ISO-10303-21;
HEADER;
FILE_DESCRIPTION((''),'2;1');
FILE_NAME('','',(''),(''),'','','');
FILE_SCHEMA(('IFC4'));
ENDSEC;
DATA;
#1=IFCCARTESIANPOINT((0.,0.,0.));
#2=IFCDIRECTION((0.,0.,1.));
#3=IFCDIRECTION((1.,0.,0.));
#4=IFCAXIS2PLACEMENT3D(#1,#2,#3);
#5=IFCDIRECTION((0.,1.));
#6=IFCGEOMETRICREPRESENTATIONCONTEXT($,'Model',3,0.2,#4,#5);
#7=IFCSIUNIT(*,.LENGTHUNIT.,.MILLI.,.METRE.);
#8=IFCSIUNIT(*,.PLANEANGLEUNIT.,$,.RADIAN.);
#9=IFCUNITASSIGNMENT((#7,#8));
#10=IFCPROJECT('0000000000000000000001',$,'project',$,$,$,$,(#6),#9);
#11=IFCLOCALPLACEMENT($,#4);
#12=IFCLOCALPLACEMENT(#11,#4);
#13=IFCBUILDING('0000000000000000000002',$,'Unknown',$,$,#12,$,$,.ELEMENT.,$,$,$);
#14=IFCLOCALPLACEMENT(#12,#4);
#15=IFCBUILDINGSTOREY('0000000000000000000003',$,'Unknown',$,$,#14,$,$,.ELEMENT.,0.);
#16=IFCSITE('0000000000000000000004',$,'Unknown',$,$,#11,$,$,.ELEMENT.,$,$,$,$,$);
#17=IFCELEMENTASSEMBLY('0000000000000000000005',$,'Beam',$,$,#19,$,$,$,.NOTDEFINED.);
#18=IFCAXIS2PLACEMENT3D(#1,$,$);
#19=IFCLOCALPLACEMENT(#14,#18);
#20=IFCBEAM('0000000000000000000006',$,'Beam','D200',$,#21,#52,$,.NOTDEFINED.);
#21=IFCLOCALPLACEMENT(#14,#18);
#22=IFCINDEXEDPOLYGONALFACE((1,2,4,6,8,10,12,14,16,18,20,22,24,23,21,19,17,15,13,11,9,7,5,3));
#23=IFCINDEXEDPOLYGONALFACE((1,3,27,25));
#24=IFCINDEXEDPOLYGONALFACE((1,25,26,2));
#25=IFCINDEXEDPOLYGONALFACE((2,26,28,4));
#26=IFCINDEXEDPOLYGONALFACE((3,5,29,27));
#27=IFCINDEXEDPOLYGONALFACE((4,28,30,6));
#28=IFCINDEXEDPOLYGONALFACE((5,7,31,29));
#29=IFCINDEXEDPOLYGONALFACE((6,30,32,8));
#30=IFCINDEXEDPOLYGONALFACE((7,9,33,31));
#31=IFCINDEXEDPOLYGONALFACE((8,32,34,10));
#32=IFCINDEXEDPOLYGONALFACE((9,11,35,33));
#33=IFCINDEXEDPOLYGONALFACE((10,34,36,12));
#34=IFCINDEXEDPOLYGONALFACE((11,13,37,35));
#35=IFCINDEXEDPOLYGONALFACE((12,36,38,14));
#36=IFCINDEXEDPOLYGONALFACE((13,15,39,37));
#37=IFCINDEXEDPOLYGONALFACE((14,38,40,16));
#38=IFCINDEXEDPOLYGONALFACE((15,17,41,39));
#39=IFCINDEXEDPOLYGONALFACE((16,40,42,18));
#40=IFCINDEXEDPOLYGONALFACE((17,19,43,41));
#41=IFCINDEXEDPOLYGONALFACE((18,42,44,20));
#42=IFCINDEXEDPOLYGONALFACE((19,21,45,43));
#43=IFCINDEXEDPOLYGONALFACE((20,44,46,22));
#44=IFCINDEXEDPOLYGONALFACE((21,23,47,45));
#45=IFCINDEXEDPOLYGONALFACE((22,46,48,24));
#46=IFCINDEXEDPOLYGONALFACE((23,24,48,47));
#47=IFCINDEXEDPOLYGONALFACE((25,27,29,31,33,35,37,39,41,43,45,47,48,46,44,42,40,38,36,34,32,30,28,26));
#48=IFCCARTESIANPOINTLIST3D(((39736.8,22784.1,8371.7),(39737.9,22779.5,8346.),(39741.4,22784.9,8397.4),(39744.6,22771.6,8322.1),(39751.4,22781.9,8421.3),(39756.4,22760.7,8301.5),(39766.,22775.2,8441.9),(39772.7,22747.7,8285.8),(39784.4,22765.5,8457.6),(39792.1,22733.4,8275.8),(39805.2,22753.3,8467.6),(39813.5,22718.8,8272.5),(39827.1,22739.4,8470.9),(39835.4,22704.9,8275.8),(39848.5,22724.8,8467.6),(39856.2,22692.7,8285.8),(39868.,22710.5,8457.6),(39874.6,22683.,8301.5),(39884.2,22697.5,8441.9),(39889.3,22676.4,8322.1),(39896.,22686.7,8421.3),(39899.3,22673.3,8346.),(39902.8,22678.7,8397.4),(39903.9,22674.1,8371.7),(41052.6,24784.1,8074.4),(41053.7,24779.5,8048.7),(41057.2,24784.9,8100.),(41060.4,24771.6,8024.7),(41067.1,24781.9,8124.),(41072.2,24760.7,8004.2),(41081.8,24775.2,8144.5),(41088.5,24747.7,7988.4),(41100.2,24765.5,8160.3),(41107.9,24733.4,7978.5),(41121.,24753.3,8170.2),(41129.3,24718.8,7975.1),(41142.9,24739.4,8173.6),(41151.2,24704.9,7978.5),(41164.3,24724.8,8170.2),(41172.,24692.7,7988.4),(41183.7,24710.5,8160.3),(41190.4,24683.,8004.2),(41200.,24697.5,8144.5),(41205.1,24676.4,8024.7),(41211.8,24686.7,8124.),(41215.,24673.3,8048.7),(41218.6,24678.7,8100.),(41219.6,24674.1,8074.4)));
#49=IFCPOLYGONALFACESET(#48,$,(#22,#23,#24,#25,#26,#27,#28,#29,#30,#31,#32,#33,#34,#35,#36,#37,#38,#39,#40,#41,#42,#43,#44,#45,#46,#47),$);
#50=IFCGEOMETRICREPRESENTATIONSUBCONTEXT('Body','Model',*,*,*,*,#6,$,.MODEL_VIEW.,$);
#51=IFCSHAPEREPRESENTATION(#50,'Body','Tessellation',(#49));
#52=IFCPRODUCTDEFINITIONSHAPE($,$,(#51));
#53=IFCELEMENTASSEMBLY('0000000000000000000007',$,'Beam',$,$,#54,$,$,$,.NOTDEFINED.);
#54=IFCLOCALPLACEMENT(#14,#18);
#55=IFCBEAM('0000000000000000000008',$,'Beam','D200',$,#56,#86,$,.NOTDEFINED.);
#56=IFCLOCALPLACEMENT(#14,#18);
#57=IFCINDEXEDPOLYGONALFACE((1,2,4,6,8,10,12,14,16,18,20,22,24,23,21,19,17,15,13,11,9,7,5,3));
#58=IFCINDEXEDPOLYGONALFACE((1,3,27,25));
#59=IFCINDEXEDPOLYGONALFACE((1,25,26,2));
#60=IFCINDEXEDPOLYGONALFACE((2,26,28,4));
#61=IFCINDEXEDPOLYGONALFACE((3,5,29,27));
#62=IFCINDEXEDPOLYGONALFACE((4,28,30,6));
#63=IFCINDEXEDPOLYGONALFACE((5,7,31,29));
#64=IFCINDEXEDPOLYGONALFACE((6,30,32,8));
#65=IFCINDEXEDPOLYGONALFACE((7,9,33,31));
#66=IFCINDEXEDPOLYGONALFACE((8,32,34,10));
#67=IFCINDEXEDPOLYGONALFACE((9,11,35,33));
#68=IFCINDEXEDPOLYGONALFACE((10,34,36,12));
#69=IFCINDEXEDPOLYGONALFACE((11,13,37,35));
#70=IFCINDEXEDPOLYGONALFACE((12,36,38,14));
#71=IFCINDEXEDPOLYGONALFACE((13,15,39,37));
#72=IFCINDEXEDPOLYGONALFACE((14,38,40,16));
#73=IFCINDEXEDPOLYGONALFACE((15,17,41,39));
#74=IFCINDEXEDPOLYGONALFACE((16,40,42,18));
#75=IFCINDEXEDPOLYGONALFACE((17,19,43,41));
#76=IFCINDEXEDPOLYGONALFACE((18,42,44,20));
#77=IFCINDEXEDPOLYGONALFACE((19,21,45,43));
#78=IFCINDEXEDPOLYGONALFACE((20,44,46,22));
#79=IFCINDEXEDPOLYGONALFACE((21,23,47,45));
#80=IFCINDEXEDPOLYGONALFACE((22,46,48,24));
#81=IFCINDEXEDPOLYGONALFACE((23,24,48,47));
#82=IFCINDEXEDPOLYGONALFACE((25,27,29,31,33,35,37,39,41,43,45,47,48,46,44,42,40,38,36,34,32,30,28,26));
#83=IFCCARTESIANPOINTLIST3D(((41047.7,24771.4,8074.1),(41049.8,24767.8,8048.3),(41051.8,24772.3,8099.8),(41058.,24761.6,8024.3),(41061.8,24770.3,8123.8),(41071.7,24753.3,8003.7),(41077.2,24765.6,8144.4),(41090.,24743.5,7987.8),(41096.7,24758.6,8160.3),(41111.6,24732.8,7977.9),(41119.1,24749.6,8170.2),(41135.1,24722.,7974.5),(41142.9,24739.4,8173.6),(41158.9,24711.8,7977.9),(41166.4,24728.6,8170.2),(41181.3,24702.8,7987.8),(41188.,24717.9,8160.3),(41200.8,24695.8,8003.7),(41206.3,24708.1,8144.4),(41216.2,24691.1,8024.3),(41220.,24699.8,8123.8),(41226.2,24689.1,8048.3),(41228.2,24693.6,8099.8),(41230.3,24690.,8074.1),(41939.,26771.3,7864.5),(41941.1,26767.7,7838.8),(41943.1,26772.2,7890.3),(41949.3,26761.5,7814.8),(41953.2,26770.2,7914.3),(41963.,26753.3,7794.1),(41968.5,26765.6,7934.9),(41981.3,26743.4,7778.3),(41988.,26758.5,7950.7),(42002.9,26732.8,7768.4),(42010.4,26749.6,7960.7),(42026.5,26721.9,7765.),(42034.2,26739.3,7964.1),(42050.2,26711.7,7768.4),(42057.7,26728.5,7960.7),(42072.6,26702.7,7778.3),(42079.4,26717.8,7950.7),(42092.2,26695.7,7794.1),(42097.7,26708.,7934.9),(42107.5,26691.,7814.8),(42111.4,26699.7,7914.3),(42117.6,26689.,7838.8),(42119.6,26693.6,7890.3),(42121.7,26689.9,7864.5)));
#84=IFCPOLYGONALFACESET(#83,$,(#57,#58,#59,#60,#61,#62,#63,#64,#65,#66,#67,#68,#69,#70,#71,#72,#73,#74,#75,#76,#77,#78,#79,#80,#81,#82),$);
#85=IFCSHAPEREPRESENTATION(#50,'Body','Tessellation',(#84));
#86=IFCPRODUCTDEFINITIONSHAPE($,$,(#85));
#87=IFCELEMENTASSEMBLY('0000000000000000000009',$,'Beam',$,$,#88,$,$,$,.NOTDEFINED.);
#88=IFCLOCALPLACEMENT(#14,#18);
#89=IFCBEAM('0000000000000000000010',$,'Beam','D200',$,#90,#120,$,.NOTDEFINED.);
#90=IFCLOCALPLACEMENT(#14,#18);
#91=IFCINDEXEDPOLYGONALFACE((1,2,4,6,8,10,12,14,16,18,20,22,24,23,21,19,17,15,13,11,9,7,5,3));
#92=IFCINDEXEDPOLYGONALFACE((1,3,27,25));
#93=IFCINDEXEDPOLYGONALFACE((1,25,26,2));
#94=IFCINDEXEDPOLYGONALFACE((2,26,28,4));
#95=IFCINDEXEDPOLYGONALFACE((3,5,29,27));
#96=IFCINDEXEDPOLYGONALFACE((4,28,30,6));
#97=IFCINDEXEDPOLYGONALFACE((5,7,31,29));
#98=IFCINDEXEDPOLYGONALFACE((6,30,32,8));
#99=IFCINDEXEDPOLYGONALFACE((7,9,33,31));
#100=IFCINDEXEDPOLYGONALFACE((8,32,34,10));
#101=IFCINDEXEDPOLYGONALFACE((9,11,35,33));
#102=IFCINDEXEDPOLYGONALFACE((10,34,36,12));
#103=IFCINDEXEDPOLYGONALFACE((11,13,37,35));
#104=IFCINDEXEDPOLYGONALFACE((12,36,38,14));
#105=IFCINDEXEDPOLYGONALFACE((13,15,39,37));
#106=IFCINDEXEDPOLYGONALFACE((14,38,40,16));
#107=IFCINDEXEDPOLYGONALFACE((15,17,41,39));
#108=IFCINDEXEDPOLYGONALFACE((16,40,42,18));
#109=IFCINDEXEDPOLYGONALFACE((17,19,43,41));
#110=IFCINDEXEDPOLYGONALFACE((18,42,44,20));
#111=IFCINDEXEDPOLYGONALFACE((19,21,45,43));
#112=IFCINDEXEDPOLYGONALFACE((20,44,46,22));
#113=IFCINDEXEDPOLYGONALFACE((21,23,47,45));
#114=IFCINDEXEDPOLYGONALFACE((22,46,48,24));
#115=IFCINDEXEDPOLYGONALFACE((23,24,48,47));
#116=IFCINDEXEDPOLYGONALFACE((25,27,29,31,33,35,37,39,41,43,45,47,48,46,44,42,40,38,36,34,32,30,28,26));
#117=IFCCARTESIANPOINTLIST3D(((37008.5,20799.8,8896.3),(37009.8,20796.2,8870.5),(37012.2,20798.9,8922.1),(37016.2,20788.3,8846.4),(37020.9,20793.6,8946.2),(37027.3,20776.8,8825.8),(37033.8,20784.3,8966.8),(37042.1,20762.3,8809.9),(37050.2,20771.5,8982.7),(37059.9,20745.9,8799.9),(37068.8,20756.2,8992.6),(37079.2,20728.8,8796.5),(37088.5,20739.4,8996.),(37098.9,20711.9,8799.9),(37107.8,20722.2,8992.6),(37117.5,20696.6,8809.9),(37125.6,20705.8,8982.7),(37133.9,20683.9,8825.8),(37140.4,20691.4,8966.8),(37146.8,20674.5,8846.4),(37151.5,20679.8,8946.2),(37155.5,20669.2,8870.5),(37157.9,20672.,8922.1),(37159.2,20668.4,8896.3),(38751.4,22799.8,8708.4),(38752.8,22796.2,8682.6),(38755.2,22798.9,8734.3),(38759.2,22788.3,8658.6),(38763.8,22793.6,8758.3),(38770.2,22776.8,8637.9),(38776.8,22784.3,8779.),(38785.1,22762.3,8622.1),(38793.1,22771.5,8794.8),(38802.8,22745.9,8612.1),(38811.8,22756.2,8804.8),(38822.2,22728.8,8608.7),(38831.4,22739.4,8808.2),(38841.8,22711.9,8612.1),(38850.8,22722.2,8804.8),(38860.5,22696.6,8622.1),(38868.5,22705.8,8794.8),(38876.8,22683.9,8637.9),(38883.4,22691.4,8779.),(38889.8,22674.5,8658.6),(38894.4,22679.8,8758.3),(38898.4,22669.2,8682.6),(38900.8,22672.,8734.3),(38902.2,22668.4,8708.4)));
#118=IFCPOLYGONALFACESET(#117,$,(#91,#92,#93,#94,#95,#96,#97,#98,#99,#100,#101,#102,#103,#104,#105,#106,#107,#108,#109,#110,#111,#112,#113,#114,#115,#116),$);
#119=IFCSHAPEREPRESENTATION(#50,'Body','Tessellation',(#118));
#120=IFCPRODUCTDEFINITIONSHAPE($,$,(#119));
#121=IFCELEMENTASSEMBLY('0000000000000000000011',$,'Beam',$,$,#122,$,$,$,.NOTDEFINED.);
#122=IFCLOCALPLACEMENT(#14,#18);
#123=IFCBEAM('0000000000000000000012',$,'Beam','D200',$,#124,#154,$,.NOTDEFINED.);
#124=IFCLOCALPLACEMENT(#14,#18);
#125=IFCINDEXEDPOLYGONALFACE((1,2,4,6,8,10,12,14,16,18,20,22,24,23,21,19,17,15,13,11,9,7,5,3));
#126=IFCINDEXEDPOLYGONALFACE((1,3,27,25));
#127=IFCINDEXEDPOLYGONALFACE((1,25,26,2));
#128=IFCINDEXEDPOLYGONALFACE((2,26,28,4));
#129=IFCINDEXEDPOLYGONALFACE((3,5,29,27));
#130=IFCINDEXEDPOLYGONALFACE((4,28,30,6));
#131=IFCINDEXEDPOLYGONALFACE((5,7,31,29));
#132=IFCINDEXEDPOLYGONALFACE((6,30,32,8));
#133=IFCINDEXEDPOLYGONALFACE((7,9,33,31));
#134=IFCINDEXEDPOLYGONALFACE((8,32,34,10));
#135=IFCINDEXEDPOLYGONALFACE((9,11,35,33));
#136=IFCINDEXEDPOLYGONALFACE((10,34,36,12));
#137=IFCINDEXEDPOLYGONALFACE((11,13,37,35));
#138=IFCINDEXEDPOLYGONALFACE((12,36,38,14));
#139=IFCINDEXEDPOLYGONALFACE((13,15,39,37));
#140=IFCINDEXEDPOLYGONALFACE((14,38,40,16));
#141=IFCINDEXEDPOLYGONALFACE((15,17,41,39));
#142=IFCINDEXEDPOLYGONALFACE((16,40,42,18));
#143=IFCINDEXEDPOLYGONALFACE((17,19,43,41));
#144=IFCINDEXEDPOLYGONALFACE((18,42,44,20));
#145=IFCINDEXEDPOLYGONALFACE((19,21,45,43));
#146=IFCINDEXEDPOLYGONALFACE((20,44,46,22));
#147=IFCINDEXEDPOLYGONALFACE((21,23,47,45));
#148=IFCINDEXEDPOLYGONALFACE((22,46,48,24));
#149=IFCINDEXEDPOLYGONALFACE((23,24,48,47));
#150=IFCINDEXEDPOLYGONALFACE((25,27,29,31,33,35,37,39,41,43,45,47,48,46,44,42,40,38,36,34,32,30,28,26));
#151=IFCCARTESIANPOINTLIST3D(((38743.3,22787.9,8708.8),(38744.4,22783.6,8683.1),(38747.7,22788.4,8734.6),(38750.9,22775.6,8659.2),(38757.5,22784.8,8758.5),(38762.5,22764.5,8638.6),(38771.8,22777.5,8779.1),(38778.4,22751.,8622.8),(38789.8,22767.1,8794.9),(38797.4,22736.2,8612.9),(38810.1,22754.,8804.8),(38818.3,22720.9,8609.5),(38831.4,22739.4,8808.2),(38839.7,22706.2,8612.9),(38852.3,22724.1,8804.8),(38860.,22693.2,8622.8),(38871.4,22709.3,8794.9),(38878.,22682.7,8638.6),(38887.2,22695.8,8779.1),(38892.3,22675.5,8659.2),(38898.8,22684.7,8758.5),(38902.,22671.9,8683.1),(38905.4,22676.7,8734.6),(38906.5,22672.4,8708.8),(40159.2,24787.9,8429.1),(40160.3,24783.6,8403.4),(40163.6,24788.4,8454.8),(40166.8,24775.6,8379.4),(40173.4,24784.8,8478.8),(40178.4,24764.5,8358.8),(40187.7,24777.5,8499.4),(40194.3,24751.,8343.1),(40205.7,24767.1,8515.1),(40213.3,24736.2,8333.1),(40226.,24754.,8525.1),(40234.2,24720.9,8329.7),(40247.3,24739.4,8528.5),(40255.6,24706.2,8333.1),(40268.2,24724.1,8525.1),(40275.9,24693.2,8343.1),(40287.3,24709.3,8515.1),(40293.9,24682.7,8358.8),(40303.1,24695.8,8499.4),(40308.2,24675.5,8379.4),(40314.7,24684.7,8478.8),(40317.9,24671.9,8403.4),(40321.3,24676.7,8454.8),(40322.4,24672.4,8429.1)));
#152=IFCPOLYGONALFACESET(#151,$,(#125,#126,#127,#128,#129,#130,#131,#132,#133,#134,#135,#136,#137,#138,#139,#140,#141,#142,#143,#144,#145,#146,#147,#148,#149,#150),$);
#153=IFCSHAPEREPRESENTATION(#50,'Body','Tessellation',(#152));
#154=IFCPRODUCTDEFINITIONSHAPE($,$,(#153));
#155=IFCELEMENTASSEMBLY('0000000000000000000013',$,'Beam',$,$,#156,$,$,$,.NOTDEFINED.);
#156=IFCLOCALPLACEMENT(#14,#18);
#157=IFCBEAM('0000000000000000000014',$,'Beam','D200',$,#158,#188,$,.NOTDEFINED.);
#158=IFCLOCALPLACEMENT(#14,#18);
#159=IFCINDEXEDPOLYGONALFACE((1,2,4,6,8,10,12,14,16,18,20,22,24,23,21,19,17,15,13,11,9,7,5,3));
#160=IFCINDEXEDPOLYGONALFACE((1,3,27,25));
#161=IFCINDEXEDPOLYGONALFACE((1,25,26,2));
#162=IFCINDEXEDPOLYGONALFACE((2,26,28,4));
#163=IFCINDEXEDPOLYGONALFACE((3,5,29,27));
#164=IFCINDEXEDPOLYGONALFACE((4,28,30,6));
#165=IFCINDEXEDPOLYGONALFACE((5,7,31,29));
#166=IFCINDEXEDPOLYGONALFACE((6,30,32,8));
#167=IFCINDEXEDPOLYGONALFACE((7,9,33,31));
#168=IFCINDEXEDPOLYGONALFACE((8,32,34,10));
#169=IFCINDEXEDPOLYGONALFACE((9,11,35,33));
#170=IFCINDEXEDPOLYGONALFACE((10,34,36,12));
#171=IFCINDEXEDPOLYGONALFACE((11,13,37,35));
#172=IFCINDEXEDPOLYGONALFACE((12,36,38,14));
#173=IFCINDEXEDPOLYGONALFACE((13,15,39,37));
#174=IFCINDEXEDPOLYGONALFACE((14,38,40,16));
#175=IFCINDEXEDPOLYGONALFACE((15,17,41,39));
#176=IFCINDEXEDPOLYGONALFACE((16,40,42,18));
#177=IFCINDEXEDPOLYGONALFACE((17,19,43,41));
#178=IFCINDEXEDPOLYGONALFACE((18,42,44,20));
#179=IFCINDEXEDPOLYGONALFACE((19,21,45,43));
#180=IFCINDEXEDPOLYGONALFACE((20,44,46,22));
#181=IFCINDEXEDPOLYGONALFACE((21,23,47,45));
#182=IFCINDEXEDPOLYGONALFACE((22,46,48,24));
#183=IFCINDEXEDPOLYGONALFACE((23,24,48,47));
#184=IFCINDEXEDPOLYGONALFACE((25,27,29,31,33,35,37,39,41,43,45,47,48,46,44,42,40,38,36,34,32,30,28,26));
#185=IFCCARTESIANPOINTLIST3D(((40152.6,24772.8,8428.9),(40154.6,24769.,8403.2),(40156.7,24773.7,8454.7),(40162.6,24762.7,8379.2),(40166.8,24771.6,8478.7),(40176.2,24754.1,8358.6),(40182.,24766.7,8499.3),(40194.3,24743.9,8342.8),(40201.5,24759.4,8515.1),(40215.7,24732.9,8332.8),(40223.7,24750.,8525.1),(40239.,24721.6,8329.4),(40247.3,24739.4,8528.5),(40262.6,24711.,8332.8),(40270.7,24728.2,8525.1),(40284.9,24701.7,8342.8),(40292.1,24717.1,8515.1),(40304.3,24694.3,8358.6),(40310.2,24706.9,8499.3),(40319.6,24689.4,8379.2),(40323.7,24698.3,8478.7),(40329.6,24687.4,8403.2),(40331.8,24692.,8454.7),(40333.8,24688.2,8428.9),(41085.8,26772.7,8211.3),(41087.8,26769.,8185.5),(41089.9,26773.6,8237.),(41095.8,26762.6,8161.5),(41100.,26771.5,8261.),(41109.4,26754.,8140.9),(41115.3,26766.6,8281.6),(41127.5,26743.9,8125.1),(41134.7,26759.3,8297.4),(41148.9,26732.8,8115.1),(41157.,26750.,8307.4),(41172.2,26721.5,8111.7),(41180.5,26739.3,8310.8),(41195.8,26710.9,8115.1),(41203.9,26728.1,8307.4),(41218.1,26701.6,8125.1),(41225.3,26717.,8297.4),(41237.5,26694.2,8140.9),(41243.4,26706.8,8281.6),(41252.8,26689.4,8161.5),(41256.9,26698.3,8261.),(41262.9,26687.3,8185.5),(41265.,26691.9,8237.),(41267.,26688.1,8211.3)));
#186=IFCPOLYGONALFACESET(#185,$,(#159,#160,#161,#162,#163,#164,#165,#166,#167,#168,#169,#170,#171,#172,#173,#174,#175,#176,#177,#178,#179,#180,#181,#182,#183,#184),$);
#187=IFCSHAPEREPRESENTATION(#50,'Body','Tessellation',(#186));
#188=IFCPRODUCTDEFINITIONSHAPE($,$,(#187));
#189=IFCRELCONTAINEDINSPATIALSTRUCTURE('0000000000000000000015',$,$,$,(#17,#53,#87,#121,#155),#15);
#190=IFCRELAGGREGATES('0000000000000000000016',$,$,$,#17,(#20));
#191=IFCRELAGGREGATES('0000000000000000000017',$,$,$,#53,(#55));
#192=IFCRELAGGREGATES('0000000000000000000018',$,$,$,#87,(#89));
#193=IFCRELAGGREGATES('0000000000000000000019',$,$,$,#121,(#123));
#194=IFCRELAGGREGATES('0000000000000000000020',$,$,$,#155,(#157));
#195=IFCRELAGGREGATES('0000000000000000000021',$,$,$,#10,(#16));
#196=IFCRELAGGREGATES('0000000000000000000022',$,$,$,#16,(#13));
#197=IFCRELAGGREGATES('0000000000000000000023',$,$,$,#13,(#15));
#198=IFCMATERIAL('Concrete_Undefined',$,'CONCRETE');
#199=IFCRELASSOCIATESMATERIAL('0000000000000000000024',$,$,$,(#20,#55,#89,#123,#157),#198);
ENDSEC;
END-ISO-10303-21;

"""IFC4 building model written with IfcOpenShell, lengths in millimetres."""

from ifc_helpers import new_model, si_unit, direction, frame, origin_with_axes, place, context, subcontext, project, spatial, line, indexed_curve, outline, extrude, material, element, aggregate, save


model = new_model("IFC4")

# Units and contexts
model_context = context("Model", 3, precision=0.2, world=origin_with_axes(), true_north=direction((0.0, 1.0)))
body_context = subcontext(model_context, "Body", "Model", "MODEL_VIEW")
ifc_project = project(units=[si_unit("LENGTHUNIT", "METRE", prefix="MILLI"), si_unit("PLANEANGLEUNIT", "RADIAN")], contexts=[model_context])

# Site, building, storey
site_placement = place(None, origin_with_axes())
site = spatial("IfcSite", under=ifc_project, at=site_placement, Name="Unknown", CompositionType="ELEMENT")
building_placement = place(site_placement, origin_with_axes())
building = spatial("IfcBuilding", under=site, at=building_placement, Name="Unknown", CompositionType="ELEMENT")
storey_placement = place(building_placement, origin_with_axes())
storey = spatial("IfcBuildingStorey", under=building, at=storey_placement, Name="Unknown", CompositionType="ELEMENT", Elevation=0.0)

# Element assemblies, beams
ifc_material = material(Name="Concrete_Undefined", Category="CONCRETE")
assembly_1_placement = place(storey_placement, frame((41136.1, 24729.1, 8074.4), z_axis=(-0.835416, 0.549618, 0.0), x_axis=(-0.545427, -0.829046, 0.123255)))
assembly_1 = element("IfcElementAssembly", 1, at=assembly_1_placement, inside=storey, Name="Beam", PredefinedType="NOTDEFINED")
beam_1_placement = place(assembly_1_placement, origin_with_axes())
beam_1 = element("IfcBeam", 2, at=beam_1_placement, material=ifc_material, Name="Beam", Description="D200", PredefinedType="NOTDEFINED", context=body_context, shape_type="SolidModel", body=[
    extrude(outline(indexed_curve([(100.0, 0.0), (96.6, 25.9), (86.6, 50.0), (70.7, 70.7), (50.0, 86.6), (25.9, 96.6), (0.0, 100.0), (-25.9, 96.6), (-50.0, 86.6), (-70.7, 70.7), (-86.6, 50.0), (-96.6, 25.9), (-100.0, 0.0), (-96.6, -25.9), (-86.6, -50.0), (-70.7, -70.7), (-50.0, -86.6), (-25.9, -96.6), (0.0, -100.0), (25.9, -96.6), (50.0, -86.6), (70.7, -70.7), (86.6, -50.0), (96.6, -25.9)], segments=[line(1, 2, 3, 4, 5, 6, 7, 8, 9, 10, 11, 12, 13, 14, 15, 16, 17, 18, 19, 20, 21, 22, 23, 24, 1)])), frame((0.0, 0.0, 0.0), z_axis=(-1.0, 0.0, 0.0), x_axis=(0.0, 0.0, 1.0)), (0.0, 0.0, -1.0), 2412.4),
])
aggregate(assembly_1, [beam_1])
assembly_2_placement = place(storey_placement, frame((42030.3, 26730.6, 7864.5), z_axis=(-0.913392, 0.407082, 0.0), x_axis=(-0.405231, -0.909239, 0.095254)))
assembly_2 = element("IfcElementAssembly", 3, at=assembly_2_placement, inside=storey, Name="Beam", PredefinedType="NOTDEFINED")
beam_2_placement = place(assembly_2_placement, origin_with_axes())
beam_2 = element("IfcBeam", 4, at=beam_2_placement, material=ifc_material, Name="Beam", Description="D200", PredefinedType="NOTDEFINED", context=body_context, shape_type="SolidModel", body=[
    extrude(outline(indexed_curve([(100.0, 0.0), (96.6, 25.9), (86.6, 50.0), (70.7, 70.7), (50.0, 86.6), (25.9, 96.6), (0.0, 100.0), (-25.9, 96.6), (-50.0, 86.6), (-70.7, 70.7), (-86.6, 50.0), (-96.6, 25.9), (-100.0, 0.0), (-96.6, -25.9), (-86.6, -50.0), (-70.7, -70.7), (-50.0, -86.6), (-25.9, -96.6), (0.0, -100.0), (25.9, -96.6), (50.0, -86.6), (70.7, -70.7), (86.6, -50.0), (96.6, -25.9)], segments=[line(1, 2, 3, 4, 5, 6, 7, 8, 9, 10, 11, 12, 13, 14, 15, 16, 17, 18, 19, 20, 21, 22, 23, 24, 1)])), frame((0.0, 0.0, 0.0), z_axis=(-1.0, 0.0, 0.0), x_axis=(0.0, 0.0, 1.0)), (0.0, 0.0, -1.0), 2199.6),
])
aggregate(assembly_2, [beam_2])
assembly_3_placement = place(storey_placement, frame((38826.8, 22734.1, 8708.4), z_axis=(-0.753891, 0.656999, 0.0), x_axis=(-0.655358, -0.752009, 0.07063)))
assembly_3 = element("IfcElementAssembly", 5, at=assembly_3_placement, inside=storey, Name="Beam", PredefinedType="NOTDEFINED")
beam_3_placement = place(assembly_3_placement, origin_with_axes())
beam_3 = element("IfcBeam", 6, at=beam_3_placement, material=ifc_material, Name="Beam", Description="D200", PredefinedType="NOTDEFINED", context=body_context, shape_type="SolidModel", body=[
    extrude(outline(indexed_curve([(100.0, 0.0), (96.6, 25.9), (86.6, 50.0), (70.7, 70.7), (50.0, 86.6), (25.9, 96.6), (0.0, 100.0), (-25.9, 96.6), (-50.0, 86.6), (-70.7, 70.7), (-86.6, 50.0), (-96.6, 25.9), (-100.0, 0.0), (-96.6, -25.9), (-86.6, -50.0), (-70.7, -70.7), (-50.0, -86.6), (-25.9, -96.6), (0.0, -100.0), (25.9, -96.6), (50.0, -86.6), (70.7, -70.7), (86.6, -50.0), (96.6, -25.9)], segments=[line(1, 2, 3, 4, 5, 6, 7, 8, 9, 10, 11, 12, 13, 14, 15, 16, 17, 18, 19, 20, 21, 22, 23, 24, 1)])), frame((0.0, 0.0, 0.0), z_axis=(-1.0, 0.0, 0.0), x_axis=(0.0, 0.0, 1.0)), (0.0, 0.0, -1.0), 2659.5),
])
aggregate(assembly_3, [beam_3])
assembly_4_placement = place(storey_placement, frame((40240.8, 24730.1, 8429.1), z_axis=(-0.816172, 0.577809, 0.0), x_axis=(-0.574081, -0.810905, 0.11342)))
assembly_4 = element("IfcElementAssembly", 7, at=assembly_4_placement, inside=storey, Name="Beam", PredefinedType="NOTDEFINED")
beam_4_placement = place(assembly_4_placement, origin_with_axes())
beam_4 = element("IfcBeam", 8, at=beam_4_placement, material=ifc_material, Name="Beam", Description="D200", PredefinedType="NOTDEFINED", context=body_context, shape_type="SolidModel", body=[
    extrude(outline(indexed_curve([(100.0, 0.0), (96.6, 25.9), (86.6, 50.0), (70.7, 70.7), (50.0, 86.6), (25.9, 96.6), (0.0, 100.0), (-25.9, 96.6), (-50.0, 86.6), (-70.7, 70.7), (-86.6, 50.0), (-96.6, 25.9), (-100.0, 0.0), (-96.6, -25.9), (-86.6, -50.0), (-70.7, -70.7), (-50.0, -86.6), (-25.9, -96.6), (0.0, -100.0), (25.9, -96.6), (50.0, -86.6), (70.7, -70.7), (86.6, -50.0), (96.6, -25.9)], segments=[line(1, 2, 3, 4, 5, 6, 7, 8, 9, 10, 11, 12, 13, 14, 15, 16, 17, 18, 19, 20, 21, 22, 23, 24, 1)])), frame((0.0, 0.0, 0.0), z_axis=(-1.0, 0.0, 0.0), x_axis=(0.0, 0.0, 1.0)), (0.0, 0.0, -1.0), 2466.4),
])
aggregate(assembly_4, [beam_4])
assembly_5_placement = place(storey_placement, frame((41176.4, 26730.4, 8211.3), z_axis=(-0.906199, 0.422852, 0.0), x_axis=(-0.42081, -0.901822, 0.098161)))
assembly_5 = element("IfcElementAssembly", 9, at=assembly_5_placement, inside=storey, Name="Beam", PredefinedType="NOTDEFINED")
beam_5_placement = place(assembly_5_placement, origin_with_axes())
beam_5 = element("IfcBeam", 10, at=beam_5_placement, material=ifc_material, Name="Beam", Description="D200", PredefinedType="NOTDEFINED", context=body_context, shape_type="SolidModel", body=[
    extrude(outline(indexed_curve([(100.0, 0.0), (96.6, 25.9), (86.6, 50.0), (70.7, 70.7), (50.0, 86.6), (25.9, 96.6), (0.0, 100.0), (-25.9, 96.6), (-50.0, 86.6), (-70.7, 70.7), (-86.6, 50.0), (-96.6, 25.9), (-100.0, 0.0), (-96.6, -25.9), (-86.6, -50.0), (-70.7, -70.7), (-50.0, -86.6), (-25.9, -96.6), (0.0, -100.0), (25.9, -96.6), (50.0, -86.6), (70.7, -70.7), (86.6, -50.0), (96.6, -25.9)], segments=[line(1, 2, 3, 4, 5, 6, 7, 8, 9, 10, 11, 12, 13, 14, 15, 16, 17, 18, 19, 20, 21, 22, 23, 24, 1)])), frame((0.0, 0.0, 0.0), z_axis=(-1.0, 0.0, 0.0), x_axis=(0.0, 0.0, 1.0)), (0.0, 0.0, -1.0), 2217.6),
])
aggregate(assembly_5, [beam_5])

save(model, "model.ifc")
